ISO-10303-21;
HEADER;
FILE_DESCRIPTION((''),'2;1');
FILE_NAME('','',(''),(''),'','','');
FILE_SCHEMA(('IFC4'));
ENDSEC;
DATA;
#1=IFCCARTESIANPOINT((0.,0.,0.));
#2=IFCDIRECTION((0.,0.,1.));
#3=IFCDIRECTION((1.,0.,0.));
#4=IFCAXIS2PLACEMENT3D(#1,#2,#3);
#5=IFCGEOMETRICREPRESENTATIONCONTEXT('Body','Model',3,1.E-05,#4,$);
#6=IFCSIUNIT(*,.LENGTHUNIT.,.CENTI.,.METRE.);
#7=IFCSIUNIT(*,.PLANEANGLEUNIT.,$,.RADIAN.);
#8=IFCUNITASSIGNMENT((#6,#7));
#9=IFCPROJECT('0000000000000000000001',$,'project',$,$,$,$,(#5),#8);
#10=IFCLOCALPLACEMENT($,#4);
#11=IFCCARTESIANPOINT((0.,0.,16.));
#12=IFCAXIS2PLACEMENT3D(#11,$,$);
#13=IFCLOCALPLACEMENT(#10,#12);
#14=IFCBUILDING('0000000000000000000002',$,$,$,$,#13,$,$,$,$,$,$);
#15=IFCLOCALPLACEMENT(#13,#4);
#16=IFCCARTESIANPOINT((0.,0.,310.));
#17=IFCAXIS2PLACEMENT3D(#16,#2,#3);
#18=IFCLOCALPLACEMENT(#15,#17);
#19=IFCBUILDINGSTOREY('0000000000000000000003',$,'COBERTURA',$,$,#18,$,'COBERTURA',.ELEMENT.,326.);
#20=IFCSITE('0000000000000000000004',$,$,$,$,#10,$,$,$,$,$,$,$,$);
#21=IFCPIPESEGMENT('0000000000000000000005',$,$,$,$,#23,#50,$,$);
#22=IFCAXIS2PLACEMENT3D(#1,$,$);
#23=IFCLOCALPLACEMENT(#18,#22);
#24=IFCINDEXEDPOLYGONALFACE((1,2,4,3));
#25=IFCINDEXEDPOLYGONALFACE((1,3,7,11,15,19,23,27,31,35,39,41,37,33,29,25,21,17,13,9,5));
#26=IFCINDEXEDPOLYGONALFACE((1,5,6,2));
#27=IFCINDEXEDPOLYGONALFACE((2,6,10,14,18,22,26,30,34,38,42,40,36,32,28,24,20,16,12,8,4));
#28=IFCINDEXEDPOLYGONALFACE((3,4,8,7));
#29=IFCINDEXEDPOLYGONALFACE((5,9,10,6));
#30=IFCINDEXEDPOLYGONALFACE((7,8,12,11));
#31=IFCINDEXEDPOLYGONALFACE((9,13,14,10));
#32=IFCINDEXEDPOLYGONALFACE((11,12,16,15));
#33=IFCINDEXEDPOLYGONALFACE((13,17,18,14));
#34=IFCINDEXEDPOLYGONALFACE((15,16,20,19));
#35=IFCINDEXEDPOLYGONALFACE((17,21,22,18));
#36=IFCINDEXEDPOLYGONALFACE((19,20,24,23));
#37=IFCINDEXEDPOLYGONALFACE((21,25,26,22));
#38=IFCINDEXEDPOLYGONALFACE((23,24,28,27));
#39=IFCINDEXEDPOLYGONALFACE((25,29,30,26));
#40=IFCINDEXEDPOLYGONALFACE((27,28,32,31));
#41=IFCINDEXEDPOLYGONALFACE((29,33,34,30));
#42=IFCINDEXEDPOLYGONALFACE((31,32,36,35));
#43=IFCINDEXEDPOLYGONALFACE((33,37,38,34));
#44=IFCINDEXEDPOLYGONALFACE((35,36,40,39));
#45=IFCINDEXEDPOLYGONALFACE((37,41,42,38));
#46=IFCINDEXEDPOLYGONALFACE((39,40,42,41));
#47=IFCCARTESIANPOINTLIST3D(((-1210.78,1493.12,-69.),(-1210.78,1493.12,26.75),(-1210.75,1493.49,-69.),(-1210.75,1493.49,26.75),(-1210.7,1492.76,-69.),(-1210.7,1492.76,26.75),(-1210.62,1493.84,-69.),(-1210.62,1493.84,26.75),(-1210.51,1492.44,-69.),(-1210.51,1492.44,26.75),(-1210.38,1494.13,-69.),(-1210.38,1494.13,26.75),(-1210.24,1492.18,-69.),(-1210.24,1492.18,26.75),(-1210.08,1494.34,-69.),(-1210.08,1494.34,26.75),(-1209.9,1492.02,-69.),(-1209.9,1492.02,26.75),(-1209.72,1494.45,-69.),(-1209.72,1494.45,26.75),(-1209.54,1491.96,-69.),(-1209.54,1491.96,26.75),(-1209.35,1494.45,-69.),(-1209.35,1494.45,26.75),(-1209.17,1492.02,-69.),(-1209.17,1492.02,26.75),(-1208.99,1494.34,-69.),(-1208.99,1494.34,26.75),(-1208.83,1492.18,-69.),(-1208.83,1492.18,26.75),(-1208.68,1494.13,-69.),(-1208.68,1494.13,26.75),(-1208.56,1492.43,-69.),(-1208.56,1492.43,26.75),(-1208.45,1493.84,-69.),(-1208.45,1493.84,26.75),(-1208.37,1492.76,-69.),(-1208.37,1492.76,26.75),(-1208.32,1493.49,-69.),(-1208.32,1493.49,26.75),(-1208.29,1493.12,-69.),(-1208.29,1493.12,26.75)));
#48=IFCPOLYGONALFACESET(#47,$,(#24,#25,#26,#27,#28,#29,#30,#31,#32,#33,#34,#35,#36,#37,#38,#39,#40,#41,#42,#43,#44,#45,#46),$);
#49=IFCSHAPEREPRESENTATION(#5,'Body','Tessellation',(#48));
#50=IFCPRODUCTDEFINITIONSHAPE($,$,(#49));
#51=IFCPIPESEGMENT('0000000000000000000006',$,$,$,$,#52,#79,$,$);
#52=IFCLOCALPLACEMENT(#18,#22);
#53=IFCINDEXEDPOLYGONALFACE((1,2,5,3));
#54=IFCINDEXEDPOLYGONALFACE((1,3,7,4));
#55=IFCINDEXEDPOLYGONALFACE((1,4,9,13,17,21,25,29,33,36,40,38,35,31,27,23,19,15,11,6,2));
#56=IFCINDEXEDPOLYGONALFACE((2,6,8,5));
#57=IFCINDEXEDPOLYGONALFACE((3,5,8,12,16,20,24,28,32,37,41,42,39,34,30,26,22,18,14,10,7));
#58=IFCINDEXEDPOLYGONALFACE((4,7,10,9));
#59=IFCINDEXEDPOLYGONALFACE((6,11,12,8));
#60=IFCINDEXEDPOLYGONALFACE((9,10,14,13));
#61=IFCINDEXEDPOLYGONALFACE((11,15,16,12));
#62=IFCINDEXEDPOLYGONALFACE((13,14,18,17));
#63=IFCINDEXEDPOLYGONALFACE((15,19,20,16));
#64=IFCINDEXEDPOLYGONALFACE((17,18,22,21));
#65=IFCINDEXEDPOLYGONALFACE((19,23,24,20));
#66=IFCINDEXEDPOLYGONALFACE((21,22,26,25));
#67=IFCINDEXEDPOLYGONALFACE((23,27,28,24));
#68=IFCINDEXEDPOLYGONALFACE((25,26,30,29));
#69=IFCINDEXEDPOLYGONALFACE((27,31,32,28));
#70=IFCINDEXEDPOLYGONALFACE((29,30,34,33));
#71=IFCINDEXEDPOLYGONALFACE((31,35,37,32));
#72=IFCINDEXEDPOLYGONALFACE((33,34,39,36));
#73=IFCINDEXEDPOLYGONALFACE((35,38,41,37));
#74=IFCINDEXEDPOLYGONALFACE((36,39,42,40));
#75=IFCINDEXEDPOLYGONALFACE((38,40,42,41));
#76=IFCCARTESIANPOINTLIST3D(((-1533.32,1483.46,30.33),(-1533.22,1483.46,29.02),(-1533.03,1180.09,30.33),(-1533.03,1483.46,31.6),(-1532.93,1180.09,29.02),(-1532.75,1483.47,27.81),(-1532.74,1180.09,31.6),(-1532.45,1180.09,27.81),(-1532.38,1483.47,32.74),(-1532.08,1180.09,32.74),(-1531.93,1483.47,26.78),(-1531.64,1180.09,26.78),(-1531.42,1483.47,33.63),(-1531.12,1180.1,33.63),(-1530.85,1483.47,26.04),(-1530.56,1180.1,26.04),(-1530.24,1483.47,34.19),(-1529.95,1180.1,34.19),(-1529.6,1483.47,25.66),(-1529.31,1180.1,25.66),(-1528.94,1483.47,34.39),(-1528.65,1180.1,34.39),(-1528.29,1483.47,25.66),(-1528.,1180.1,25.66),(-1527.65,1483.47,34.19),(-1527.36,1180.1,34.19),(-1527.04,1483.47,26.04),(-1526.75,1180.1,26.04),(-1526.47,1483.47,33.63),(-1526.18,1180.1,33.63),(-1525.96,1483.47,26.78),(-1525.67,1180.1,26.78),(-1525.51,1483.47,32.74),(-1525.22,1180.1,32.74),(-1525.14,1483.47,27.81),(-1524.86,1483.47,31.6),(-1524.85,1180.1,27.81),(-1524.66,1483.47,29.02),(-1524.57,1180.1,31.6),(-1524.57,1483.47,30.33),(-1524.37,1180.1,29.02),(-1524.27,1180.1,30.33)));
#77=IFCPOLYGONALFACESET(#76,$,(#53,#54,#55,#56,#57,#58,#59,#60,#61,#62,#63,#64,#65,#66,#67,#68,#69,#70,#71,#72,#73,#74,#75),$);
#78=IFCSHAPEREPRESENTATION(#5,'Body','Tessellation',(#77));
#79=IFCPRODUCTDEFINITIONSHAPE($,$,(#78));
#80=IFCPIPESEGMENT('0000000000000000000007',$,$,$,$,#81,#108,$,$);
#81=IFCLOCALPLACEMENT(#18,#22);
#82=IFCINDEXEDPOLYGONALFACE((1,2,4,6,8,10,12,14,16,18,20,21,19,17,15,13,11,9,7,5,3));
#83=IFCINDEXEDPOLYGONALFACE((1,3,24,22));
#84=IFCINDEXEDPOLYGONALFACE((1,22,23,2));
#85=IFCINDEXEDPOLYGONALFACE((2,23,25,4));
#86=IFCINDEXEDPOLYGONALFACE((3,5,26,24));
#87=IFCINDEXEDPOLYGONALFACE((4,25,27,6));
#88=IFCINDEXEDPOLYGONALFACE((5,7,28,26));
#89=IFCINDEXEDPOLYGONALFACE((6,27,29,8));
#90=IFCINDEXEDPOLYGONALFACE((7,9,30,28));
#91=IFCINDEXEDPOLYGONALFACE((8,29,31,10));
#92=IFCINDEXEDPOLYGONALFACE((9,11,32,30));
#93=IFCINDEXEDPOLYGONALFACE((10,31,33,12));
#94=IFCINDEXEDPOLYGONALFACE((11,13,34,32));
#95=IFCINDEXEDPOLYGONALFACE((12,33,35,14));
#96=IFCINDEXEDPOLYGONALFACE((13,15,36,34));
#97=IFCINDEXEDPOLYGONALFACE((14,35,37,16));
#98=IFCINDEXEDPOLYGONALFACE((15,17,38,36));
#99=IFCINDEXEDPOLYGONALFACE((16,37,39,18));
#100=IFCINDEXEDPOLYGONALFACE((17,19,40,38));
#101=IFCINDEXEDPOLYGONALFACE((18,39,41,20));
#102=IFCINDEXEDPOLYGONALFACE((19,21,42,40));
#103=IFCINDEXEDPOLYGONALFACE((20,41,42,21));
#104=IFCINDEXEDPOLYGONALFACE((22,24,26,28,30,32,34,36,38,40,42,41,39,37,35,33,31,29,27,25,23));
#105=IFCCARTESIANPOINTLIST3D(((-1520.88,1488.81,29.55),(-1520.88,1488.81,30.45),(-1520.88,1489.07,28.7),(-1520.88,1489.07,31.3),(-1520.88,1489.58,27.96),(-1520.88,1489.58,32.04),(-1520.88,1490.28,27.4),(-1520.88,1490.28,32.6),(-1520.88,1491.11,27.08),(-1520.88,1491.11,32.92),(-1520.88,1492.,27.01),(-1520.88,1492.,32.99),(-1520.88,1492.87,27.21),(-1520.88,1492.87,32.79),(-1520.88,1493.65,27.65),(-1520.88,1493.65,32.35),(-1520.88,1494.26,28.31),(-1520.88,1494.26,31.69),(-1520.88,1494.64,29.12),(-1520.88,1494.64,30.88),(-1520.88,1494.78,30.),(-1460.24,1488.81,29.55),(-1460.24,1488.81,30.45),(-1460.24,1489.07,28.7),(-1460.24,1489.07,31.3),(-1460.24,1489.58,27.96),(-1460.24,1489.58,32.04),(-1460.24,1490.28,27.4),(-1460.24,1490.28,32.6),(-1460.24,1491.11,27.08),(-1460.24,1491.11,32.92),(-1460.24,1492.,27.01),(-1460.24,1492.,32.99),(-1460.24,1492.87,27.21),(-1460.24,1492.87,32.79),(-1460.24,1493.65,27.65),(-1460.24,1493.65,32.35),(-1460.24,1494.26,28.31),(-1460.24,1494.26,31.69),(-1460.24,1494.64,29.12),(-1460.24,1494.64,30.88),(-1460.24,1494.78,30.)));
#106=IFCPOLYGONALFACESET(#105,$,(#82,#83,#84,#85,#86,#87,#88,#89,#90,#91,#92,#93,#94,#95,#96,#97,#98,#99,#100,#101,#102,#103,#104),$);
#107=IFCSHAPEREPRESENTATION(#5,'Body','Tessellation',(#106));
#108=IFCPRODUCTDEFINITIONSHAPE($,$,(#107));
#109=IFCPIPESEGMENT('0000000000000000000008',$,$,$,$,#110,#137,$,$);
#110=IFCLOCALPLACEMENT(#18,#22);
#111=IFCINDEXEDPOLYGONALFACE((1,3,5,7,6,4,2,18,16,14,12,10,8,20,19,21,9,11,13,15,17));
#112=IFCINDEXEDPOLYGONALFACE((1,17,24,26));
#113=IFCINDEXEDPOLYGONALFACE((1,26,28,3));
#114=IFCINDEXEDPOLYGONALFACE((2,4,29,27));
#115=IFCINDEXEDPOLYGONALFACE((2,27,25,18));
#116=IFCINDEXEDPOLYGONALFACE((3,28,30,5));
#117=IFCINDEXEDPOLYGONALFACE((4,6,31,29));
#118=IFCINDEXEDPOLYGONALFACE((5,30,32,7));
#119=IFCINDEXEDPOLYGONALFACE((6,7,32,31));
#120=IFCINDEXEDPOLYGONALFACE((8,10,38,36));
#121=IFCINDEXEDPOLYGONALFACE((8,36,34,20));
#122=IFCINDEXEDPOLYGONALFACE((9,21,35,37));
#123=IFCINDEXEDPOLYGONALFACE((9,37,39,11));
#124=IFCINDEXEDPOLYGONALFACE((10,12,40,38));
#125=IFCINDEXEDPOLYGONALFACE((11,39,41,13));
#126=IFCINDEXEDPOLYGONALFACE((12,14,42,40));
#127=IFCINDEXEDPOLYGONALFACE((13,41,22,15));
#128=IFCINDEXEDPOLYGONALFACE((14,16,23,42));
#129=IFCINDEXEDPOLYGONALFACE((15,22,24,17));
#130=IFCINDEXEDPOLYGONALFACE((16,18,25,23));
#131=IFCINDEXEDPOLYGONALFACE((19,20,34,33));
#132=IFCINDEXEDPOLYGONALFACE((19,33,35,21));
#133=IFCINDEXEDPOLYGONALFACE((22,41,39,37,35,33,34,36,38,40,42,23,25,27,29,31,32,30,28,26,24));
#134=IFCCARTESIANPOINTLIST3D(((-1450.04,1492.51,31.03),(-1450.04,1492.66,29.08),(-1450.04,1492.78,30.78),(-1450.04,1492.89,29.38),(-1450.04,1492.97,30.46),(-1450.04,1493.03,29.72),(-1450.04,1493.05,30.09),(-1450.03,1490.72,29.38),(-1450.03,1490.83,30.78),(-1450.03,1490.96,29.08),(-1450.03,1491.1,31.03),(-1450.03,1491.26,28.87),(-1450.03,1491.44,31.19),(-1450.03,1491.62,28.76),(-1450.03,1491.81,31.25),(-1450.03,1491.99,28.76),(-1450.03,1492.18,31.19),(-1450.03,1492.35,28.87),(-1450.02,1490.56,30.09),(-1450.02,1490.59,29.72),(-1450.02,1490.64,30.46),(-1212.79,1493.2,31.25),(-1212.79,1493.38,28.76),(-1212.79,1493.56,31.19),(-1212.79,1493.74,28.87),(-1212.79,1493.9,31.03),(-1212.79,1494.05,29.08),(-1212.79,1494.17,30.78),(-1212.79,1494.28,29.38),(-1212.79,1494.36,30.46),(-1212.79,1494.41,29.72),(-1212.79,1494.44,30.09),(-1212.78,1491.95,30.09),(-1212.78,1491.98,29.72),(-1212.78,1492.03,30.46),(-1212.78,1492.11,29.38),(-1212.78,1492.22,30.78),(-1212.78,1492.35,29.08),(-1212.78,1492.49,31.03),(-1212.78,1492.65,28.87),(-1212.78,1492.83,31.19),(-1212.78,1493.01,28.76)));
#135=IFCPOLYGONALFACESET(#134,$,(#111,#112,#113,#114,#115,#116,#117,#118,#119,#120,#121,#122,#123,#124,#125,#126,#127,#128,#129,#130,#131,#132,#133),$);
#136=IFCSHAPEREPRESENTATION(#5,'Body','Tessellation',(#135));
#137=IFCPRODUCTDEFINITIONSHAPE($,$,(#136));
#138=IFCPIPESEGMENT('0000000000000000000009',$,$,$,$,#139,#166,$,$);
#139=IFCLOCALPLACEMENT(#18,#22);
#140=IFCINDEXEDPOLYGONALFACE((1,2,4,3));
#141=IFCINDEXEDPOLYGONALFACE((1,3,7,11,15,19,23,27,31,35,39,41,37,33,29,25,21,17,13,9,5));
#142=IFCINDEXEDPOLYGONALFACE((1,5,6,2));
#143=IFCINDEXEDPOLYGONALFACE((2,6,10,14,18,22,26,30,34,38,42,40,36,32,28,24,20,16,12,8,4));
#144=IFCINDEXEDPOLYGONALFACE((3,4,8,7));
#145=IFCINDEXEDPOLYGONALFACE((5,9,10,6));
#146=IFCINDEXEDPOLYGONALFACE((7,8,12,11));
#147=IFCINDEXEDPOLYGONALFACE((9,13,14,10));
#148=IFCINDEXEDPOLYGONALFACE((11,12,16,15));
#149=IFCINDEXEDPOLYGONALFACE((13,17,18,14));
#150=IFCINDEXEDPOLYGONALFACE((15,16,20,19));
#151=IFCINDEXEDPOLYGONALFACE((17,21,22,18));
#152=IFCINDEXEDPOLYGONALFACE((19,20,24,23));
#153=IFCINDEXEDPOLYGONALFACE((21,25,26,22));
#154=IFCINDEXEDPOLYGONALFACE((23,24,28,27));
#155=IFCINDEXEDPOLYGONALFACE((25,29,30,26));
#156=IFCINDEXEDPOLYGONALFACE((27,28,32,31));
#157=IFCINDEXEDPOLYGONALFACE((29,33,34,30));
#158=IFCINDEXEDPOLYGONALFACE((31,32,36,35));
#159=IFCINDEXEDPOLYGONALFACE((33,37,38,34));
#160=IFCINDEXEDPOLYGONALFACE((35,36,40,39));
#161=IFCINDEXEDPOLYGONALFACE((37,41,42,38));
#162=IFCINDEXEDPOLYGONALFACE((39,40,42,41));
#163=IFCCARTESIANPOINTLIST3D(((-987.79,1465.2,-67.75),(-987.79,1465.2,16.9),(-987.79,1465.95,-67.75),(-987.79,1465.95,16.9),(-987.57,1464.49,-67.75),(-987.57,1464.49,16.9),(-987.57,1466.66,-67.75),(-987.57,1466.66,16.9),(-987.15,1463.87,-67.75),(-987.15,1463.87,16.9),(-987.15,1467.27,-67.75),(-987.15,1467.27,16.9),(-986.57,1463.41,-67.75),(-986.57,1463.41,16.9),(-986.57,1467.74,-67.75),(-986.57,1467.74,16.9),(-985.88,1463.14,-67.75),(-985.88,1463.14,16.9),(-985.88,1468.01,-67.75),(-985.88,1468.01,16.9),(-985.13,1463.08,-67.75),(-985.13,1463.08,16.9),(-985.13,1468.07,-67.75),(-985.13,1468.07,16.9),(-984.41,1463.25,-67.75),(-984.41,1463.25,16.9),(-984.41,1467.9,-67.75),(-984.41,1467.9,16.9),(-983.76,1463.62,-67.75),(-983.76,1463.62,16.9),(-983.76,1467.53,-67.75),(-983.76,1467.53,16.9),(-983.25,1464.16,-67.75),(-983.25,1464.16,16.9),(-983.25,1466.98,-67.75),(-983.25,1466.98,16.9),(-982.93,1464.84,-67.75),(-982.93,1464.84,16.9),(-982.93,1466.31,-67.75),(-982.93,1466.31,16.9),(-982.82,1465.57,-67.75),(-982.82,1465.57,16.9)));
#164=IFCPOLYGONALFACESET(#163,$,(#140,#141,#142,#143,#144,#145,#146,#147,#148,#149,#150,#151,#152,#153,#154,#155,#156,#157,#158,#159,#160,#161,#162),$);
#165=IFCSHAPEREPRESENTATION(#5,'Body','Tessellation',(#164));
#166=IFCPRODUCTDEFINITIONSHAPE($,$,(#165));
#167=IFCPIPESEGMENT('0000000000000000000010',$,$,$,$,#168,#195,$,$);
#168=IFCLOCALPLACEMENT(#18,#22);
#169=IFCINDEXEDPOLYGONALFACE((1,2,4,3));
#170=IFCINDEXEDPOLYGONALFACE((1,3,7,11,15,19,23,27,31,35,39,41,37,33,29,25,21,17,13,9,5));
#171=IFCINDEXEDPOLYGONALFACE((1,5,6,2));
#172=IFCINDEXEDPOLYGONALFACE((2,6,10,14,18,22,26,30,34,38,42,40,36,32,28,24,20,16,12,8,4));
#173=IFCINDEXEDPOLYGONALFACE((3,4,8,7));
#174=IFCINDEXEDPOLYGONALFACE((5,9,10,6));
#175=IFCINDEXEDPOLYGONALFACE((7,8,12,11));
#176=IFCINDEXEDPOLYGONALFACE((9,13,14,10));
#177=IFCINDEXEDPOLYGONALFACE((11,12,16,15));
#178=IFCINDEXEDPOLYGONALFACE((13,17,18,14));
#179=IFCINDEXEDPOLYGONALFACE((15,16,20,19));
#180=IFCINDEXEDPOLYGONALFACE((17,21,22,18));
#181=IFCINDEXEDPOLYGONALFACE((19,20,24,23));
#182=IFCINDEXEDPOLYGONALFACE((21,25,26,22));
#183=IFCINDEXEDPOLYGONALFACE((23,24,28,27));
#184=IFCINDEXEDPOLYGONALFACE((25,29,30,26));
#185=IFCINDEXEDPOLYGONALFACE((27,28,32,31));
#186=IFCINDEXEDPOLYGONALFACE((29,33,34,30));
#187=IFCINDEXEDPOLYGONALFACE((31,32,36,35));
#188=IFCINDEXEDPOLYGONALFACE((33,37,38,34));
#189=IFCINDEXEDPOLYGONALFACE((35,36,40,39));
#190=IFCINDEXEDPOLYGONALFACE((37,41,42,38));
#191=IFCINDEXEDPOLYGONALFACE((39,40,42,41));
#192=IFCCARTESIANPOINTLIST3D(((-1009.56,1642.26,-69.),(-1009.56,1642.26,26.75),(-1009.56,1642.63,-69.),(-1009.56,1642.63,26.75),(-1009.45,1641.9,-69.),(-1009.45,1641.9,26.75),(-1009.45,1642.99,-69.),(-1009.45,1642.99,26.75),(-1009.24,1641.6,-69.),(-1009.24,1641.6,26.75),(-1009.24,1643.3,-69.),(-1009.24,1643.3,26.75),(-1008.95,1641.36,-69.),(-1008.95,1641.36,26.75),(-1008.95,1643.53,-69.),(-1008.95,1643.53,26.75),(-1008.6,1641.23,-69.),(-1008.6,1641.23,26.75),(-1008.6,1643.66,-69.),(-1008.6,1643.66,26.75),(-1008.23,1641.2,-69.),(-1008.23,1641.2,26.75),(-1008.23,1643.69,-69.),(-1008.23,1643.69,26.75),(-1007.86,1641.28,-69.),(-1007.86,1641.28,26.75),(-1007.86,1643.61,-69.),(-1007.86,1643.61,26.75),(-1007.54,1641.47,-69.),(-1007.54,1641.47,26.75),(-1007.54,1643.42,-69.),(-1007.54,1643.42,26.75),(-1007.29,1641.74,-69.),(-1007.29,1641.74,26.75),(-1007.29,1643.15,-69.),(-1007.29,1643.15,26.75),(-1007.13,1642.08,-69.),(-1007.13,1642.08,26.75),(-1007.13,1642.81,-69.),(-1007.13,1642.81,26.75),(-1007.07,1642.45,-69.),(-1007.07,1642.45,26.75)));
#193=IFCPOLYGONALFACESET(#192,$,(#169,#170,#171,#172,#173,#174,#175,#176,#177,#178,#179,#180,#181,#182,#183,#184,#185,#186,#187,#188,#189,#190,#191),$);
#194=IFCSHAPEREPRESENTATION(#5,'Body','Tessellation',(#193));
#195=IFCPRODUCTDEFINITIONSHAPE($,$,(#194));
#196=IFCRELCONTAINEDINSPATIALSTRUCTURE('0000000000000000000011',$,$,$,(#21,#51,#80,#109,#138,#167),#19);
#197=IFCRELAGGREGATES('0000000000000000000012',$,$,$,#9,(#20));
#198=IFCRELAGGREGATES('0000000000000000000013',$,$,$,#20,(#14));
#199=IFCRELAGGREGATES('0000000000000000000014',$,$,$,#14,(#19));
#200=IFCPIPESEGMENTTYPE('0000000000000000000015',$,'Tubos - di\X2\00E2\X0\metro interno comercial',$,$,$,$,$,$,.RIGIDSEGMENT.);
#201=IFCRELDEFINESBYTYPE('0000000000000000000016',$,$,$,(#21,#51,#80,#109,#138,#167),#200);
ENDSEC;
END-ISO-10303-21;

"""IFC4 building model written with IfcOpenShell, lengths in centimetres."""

from ifc_helpers import new_model, si_unit, frame, origin_with_axes, origin_2d_with_axis, place, context, project, spatial, circle, extrude, type_object, element, save


model = new_model("IFC4")

# Units and contexts
model_context = context("Model", 3, precision=1e-05, world=origin_with_axes(), identifier="Body")
ifc_project = project(units=[si_unit("LENGTHUNIT", "METRE", prefix="CENTI"), si_unit("PLANEANGLEUNIT", "RADIAN")], contexts=[model_context])

# Site, building, storey
site_placement = place(None, origin_with_axes())
site = spatial("IfcSite", under=ifc_project, at=site_placement)
building_placement = place(site_placement, frame((0.0, 0.0, 16.0)))
building = spatial("IfcBuilding", under=site, at=building_placement)
placement = place(building_placement, origin_with_axes())
storey_placement = place(placement, frame((0.0, 0.0, 310.0), z_axis=(0.0, 0.0, 1.0), x_axis=(1.0, 0.0, 0.0)))
storey = spatial("IfcBuildingStorey", under=building, at=storey_placement, Name="COBERTURA", LongName="COBERTURA", CompositionType="ELEMENT", Elevation=326.0)

# Pipe segments
pipe_segment_type = type_object("IfcPipeSegmentType", Name="Tubos - diâmetro interno comercial", PredefinedType="RIGIDSEGMENT")
pipe_segment_1_placement = place(storey_placement, frame((-1209.54, 1493.21, 26.75), z_axis=(0.0, 0.0, 1.0), x_axis=(1.0, 0.0, 0.0)))
element("IfcPipeSegment", 1, at=pipe_segment_1_placement, inside=storey, type_object=pipe_segment_type, context=model_context, shape_type="SolidModel", body=[
    extrude(circle(Radius=1.25, at=origin_2d_with_axis()), frame((0.0, 0.0, 0.0), z_axis=(0.0, 0.0, -1.0), x_axis=(-0.865725, 0.50052, 0.0)), (0.0, 0.0, 1.0), 95.75),
])
pipe_segment_2_placement = place(storey_placement, frame((-1528.8, 1331.78, 34.39), z_axis=(0.0, 0.0, 1.0), x_axis=(1.0, 0.0, 0.0)))
element("IfcPipeSegment", 2, at=pipe_segment_2_placement, inside=storey, type_object=pipe_segment_type, context=model_context, shape_type="SolidModel", body=[
    extrude(circle(Radius=4.39, at=origin_2d_with_axis()), frame((-0.15, 151.69, -4.39), z_axis=(0.000964, -1.0, 0.0), x_axis=(0.0, 0.0, 1.0)), (0.0, 0.0, 1.0), 303.37),
])
pipe_segment_3_placement = place(storey_placement, frame((-1490.56, 1491.78, 33.0), z_axis=(0.0, 0.0, 1.0), x_axis=(1.0, 0.0, 0.0)))
element("IfcPipeSegment", 3, at=pipe_segment_3_placement, inside=storey, type_object=pipe_segment_type, context=model_context, shape_type="SolidModel", body=[
    extrude(circle(Radius=3.0, at=origin_2d_with_axis()), frame((-30.32, 0.0, -3.0), z_axis=(1.0, 0.0, 0.0), x_axis=(0.0, 1.0, 0.0)), (0.0, 0.0, 1.0), 60.63),
])
pipe_segment_4_placement = place(storey_placement, frame((-1331.41, 1492.5, 31.25), z_axis=(0.0, 0.0, 1.0), x_axis=(1.0, 0.0, 0.0)))
element("IfcPipeSegment", 4, at=pipe_segment_4_placement, inside=storey, type_object=pipe_segment_type, context=model_context, shape_type="SolidModel", body=[
    extrude(circle(Radius=1.25, at=origin_2d_with_axis()), frame((-118.62, -0.69, -1.25), z_axis=(1.0, 0.005853, 0.0), x_axis=(0.0, 0.0, 1.0)), (0.0, 0.0, 1.0), 237.25),
])
pipe_segment_5_placement = place(storey_placement, frame((-985.32, 1465.57, 16.9), z_axis=(0.0, 0.0, 1.0), x_axis=(1.0, 0.0, 0.0)))
element("IfcPipeSegment", 5, at=pipe_segment_5_placement, inside=storey, type_object=pipe_segment_type, context=model_context, shape_type="SolidModel", body=[
    extrude(circle(Radius=2.5, at=origin_2d_with_axis()), frame((0.0, 0.0, 0.0), z_axis=(0.0, 0.0, -1.0), x_axis=(1.0, 0.0, 0.0)), (0.0, 0.0, 1.0), 84.65),
])
pipe_segment_6_placement = place(storey_placement, frame((-1008.32, 1642.45, 26.75), z_axis=(0.0, 0.0, 1.0), x_axis=(1.0, 0.0, 0.0)))
element("IfcPipeSegment", 6, at=pipe_segment_6_placement, inside=storey, type_object=pipe_segment_type, context=model_context, shape_type="SolidModel", body=[
    extrude(circle(Radius=1.25, at=origin_2d_with_axis()), frame((0.0, 0.0, 0.0), z_axis=(0.0, 0.0, -1.0), x_axis=(1.0, 0.0, 0.0)), (0.0, 0.0, 1.0), 95.75),
])

save(model, "model.ifc")
